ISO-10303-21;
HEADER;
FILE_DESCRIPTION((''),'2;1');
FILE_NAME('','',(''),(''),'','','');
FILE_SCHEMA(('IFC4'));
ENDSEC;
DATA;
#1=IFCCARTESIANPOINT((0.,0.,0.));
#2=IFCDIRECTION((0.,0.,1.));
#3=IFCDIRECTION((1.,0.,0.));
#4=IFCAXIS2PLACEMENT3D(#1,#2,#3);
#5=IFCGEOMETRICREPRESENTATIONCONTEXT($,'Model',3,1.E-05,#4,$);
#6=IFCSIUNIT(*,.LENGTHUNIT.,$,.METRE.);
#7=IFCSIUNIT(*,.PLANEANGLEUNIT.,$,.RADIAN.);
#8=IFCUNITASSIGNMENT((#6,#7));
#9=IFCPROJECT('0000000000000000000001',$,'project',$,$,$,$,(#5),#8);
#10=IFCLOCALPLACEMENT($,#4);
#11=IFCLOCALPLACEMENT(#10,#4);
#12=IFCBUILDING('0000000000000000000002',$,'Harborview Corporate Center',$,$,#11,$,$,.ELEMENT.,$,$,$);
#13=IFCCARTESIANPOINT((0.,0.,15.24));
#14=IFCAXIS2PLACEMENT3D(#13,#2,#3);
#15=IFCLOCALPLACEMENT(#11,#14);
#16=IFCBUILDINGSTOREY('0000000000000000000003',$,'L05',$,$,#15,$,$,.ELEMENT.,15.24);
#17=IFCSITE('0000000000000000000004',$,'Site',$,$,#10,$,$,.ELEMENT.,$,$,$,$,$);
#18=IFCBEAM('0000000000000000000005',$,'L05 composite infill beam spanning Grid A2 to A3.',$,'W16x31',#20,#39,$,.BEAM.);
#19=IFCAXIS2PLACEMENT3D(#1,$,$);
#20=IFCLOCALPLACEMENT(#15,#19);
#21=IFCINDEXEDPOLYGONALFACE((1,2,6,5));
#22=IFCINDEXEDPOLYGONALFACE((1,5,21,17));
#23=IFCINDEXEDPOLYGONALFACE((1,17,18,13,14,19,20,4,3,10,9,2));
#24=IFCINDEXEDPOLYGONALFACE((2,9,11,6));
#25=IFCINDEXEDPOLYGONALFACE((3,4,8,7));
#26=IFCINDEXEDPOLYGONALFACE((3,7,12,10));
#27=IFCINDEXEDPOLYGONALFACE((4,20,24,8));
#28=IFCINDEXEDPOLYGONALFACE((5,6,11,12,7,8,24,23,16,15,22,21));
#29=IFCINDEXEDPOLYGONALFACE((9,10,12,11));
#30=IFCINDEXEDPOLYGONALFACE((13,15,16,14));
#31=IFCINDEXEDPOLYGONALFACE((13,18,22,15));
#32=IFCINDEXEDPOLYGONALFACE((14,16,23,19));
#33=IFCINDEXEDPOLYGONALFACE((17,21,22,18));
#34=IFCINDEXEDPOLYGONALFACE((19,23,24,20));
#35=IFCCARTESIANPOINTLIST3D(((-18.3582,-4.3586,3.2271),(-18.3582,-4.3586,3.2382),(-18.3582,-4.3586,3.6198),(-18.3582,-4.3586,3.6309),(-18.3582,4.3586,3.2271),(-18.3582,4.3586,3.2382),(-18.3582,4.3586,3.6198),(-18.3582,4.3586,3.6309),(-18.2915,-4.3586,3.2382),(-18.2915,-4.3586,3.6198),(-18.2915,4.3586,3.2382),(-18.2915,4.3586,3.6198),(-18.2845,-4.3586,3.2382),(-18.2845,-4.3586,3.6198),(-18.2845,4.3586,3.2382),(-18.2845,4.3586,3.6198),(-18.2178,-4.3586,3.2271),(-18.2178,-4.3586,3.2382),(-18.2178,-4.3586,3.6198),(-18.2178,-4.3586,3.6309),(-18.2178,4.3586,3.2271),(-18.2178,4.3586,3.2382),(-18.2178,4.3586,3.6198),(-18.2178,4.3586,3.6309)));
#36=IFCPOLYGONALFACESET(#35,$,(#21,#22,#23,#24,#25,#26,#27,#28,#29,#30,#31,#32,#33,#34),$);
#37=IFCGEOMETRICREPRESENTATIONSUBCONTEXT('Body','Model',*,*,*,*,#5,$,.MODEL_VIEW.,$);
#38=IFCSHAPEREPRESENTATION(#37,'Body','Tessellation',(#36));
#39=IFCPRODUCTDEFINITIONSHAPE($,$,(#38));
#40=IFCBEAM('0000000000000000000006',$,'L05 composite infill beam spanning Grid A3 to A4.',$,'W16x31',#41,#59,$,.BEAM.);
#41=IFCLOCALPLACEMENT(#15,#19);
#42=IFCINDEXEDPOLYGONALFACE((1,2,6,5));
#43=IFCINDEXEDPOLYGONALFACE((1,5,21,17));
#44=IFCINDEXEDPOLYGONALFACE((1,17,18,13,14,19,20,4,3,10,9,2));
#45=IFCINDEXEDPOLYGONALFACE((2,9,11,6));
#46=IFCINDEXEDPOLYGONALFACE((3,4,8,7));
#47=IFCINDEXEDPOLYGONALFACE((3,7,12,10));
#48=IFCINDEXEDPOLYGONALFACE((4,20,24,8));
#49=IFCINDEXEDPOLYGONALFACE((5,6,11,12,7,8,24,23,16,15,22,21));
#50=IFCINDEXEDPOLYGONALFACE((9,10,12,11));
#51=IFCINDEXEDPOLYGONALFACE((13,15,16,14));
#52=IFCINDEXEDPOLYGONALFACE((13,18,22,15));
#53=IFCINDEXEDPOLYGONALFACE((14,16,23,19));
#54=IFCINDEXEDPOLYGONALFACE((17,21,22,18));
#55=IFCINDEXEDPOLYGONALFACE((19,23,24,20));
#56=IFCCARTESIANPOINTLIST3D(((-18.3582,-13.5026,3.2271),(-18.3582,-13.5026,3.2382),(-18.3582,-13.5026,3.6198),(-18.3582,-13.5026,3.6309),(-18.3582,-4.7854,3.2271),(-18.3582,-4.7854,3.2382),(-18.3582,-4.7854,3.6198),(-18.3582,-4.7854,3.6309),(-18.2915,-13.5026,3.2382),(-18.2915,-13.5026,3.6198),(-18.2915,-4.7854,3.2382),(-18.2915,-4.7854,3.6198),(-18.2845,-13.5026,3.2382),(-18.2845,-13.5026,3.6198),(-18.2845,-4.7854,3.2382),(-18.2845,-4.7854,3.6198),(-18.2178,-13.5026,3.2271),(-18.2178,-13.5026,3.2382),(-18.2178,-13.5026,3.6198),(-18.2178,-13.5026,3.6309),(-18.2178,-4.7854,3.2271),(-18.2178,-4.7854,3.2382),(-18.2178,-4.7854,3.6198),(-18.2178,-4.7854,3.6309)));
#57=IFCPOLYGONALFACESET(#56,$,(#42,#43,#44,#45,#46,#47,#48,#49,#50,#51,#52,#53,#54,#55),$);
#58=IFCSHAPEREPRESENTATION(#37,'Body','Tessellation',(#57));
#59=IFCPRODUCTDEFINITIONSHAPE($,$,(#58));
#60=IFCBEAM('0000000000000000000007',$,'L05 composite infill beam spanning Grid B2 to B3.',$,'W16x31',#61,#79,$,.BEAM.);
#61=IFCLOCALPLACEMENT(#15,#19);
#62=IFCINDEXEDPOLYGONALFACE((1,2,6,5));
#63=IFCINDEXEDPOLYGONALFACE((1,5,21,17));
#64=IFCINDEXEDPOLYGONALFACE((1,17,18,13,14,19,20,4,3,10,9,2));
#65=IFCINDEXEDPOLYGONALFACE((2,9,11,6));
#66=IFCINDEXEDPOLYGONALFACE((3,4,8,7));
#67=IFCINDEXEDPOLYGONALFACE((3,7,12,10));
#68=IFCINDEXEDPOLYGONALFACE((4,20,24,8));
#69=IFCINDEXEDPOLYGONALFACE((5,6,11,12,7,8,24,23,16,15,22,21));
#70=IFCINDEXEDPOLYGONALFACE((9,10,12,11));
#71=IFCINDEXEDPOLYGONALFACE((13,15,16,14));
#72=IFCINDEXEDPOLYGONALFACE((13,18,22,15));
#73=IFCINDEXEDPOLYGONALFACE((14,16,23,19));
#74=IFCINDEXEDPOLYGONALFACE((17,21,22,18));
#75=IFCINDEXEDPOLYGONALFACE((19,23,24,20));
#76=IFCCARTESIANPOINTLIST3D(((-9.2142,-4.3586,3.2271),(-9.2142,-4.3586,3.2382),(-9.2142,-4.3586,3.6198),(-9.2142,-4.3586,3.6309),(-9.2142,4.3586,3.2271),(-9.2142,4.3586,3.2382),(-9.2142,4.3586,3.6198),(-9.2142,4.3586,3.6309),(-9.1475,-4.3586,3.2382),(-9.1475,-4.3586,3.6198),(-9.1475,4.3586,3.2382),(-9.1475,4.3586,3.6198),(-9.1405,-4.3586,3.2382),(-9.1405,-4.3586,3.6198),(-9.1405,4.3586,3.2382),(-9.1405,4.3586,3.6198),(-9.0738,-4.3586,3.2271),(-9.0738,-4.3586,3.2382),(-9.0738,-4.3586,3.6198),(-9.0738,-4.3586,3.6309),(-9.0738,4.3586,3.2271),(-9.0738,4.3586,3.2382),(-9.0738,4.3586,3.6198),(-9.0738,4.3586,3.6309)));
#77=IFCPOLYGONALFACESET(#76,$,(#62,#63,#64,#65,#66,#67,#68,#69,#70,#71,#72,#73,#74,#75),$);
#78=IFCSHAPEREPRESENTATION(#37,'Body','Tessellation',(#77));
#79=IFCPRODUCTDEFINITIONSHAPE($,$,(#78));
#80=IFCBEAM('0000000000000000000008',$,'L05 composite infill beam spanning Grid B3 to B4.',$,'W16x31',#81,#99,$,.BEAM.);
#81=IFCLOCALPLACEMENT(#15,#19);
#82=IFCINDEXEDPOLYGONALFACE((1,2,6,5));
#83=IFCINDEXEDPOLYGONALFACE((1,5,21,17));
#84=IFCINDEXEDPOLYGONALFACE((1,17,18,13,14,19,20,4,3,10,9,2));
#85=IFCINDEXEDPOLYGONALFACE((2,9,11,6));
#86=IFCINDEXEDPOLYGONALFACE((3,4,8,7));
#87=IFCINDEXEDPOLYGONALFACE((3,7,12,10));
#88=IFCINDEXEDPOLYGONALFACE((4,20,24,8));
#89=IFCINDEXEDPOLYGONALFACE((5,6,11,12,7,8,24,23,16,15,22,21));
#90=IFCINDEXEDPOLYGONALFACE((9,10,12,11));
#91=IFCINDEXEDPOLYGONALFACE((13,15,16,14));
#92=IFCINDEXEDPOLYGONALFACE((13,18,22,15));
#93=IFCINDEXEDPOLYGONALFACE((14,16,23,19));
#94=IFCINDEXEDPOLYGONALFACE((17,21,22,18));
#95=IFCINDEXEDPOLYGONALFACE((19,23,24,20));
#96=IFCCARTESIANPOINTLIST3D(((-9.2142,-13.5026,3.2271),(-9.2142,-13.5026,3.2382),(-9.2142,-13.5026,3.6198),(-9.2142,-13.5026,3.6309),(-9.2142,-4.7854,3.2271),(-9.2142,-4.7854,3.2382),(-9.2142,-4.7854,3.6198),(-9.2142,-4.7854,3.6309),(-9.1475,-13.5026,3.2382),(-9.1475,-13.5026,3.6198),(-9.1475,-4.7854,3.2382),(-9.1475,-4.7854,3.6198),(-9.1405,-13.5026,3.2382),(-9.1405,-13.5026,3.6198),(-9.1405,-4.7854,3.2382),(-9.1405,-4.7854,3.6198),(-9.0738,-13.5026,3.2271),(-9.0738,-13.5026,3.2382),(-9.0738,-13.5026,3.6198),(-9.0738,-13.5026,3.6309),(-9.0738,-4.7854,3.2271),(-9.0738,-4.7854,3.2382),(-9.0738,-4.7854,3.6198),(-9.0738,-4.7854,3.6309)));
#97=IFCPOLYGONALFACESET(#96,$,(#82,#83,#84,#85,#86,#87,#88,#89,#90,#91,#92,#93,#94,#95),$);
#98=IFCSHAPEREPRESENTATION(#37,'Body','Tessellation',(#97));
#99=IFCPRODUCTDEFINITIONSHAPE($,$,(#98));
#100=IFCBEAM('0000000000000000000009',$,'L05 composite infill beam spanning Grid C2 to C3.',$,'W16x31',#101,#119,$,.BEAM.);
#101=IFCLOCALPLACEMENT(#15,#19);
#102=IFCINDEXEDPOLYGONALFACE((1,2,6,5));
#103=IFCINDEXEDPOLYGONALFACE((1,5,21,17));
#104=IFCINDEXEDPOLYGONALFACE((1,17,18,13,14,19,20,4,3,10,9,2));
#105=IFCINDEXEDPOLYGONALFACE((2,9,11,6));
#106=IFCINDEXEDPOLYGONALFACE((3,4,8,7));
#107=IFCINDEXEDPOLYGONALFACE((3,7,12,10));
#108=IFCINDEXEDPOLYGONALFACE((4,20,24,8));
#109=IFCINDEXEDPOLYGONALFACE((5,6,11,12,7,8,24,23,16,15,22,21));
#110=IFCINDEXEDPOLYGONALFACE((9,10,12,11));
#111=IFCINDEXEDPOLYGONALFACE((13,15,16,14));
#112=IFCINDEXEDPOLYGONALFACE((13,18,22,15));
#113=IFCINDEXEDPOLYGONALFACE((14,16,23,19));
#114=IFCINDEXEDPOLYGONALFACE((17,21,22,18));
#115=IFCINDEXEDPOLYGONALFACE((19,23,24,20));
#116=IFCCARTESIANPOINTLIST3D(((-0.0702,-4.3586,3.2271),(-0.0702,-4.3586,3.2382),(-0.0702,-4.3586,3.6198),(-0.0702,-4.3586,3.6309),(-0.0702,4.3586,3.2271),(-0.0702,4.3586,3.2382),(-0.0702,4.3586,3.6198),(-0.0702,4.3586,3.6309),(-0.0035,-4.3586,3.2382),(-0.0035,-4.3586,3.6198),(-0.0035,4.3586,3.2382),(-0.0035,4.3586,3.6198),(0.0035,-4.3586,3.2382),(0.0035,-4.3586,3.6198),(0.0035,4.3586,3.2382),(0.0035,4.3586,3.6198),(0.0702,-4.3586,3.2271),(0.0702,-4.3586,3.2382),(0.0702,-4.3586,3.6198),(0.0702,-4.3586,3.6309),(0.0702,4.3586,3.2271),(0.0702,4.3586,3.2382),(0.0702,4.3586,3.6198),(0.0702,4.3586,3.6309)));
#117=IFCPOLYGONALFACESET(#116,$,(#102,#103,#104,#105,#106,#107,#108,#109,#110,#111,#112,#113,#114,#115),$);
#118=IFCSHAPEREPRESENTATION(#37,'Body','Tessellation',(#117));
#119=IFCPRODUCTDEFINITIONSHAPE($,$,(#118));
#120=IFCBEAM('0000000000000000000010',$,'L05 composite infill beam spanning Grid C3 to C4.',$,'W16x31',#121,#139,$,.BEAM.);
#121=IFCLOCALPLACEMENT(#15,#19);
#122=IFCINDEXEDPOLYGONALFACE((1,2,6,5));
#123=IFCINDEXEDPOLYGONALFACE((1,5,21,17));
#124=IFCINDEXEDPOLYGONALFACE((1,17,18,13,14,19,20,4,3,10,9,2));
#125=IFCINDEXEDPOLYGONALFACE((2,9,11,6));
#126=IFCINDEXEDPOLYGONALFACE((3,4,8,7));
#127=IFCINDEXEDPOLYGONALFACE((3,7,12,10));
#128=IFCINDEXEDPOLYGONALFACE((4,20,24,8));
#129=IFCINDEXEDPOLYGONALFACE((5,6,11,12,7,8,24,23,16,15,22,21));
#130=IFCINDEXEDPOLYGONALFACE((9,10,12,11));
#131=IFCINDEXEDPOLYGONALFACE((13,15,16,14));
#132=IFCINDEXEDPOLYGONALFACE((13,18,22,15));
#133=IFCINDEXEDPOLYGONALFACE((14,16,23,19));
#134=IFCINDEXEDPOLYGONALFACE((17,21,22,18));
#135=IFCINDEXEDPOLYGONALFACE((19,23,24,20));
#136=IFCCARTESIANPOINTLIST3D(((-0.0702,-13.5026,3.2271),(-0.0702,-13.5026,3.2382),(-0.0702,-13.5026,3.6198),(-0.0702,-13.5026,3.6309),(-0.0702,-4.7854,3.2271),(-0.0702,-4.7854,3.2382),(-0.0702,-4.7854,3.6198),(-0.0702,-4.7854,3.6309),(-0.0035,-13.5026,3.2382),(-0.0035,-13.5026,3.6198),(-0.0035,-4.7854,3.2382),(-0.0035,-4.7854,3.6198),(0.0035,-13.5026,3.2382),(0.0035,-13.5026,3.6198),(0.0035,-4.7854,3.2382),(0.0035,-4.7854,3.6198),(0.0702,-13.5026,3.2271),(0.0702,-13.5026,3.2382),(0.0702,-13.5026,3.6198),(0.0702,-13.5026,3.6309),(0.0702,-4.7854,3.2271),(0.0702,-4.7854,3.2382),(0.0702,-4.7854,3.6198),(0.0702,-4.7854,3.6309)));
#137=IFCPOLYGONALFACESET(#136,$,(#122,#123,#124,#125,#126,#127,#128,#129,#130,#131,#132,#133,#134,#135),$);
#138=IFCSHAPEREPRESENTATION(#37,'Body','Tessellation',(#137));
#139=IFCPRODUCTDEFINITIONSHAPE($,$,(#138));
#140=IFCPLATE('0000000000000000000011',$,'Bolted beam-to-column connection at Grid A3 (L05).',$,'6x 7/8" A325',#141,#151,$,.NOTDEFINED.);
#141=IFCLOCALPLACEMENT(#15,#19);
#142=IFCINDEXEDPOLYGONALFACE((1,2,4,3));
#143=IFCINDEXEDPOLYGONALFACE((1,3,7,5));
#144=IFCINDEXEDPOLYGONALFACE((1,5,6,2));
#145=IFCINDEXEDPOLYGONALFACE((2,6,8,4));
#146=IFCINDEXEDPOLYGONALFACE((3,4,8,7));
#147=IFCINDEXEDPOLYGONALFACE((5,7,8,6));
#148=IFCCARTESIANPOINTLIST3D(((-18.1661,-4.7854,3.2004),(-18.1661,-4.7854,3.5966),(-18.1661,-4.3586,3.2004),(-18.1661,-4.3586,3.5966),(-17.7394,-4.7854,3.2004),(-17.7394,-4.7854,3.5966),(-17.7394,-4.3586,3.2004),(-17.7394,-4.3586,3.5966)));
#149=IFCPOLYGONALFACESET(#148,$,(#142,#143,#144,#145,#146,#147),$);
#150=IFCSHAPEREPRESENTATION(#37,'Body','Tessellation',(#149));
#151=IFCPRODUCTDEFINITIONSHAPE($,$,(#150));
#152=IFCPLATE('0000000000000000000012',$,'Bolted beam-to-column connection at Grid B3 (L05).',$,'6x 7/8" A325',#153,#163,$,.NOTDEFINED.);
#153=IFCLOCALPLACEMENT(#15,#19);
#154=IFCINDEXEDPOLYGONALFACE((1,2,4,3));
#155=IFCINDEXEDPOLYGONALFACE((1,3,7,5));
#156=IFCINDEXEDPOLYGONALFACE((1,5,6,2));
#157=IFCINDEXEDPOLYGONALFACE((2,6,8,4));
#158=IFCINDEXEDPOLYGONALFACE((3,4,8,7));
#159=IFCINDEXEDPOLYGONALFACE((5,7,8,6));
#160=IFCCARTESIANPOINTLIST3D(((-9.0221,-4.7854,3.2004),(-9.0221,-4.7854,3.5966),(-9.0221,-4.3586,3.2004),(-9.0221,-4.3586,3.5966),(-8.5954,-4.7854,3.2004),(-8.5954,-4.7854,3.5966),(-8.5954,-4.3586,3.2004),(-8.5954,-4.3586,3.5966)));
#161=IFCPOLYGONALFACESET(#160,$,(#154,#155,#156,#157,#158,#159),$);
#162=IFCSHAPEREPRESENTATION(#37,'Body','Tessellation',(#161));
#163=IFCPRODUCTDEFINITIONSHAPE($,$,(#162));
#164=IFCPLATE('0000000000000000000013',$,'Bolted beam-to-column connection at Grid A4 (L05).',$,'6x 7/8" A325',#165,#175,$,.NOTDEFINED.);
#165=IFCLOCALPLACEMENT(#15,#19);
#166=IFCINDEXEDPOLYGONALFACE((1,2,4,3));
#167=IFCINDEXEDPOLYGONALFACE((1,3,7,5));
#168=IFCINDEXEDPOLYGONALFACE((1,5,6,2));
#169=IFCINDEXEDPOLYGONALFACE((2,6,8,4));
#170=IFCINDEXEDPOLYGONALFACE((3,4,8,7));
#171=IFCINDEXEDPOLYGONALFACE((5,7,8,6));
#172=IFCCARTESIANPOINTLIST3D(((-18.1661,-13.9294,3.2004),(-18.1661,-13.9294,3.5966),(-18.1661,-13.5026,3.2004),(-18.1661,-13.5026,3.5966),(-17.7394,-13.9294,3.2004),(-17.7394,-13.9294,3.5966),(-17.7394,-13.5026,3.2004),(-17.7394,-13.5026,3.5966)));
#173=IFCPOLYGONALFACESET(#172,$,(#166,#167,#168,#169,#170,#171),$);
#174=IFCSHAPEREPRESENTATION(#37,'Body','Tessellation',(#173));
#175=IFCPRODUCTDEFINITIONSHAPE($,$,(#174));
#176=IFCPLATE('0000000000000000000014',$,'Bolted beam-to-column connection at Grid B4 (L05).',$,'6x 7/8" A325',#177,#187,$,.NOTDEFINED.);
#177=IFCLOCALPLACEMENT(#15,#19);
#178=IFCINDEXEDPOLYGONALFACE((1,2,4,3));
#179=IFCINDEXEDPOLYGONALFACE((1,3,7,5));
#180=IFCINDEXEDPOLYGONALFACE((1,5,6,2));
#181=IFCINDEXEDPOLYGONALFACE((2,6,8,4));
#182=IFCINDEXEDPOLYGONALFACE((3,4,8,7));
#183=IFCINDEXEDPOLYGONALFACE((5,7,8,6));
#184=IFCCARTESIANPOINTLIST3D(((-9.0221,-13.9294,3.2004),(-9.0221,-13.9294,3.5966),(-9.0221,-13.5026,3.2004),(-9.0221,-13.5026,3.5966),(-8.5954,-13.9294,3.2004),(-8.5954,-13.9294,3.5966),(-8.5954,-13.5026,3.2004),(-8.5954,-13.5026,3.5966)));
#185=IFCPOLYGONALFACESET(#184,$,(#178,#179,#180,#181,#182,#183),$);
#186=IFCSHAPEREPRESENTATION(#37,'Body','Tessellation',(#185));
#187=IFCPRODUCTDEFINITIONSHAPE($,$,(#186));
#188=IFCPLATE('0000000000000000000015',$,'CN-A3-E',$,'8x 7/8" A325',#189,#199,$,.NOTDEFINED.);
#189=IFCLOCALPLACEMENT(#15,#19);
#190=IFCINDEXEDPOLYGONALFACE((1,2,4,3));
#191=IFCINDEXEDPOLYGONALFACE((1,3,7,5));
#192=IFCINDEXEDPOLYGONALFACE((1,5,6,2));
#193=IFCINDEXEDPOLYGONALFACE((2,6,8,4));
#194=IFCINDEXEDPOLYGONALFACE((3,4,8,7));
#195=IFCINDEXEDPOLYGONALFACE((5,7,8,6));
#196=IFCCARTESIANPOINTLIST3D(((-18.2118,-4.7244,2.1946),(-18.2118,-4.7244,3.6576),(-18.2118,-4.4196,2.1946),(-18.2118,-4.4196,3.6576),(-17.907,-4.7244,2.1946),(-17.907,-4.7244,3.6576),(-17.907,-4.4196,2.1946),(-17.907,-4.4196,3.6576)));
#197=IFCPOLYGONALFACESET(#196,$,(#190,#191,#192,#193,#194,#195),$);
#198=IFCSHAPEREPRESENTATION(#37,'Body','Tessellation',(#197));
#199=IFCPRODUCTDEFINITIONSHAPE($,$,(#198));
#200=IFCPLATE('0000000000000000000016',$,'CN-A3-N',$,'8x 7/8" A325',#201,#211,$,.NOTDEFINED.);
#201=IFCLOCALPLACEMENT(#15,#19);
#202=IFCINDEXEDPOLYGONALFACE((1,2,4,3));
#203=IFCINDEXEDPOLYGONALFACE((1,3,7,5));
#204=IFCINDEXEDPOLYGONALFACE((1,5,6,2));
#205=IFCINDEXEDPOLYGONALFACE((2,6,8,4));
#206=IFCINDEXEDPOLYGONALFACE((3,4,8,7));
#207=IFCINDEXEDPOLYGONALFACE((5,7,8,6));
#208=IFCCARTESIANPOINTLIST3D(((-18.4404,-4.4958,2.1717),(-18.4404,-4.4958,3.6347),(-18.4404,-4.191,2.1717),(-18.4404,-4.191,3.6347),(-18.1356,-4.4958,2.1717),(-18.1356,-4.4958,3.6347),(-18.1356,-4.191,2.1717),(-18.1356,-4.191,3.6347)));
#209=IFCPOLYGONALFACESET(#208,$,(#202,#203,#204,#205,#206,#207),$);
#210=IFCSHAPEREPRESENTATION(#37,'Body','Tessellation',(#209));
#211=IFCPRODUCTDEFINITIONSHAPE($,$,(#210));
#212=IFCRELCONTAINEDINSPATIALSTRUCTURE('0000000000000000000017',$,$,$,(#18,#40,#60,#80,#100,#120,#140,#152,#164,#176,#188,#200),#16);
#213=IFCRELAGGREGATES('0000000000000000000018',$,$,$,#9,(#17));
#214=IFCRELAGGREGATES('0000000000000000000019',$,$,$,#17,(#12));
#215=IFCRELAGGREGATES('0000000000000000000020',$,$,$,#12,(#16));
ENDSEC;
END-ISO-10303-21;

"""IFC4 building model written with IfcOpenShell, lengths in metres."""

from ifc_helpers import new_model, si_unit, frame, origin_with_axes, place, context, subcontext, project, spatial, rectangle, i_section, extrude, element, save


model = new_model("IFC4")

# Units and contexts
model_context = context("Model", 3, precision=1e-05, world=origin_with_axes())
body_context = subcontext(model_context, "Body", "Model", "MODEL_VIEW")
ifc_project = project(units=[si_unit("LENGTHUNIT", "METRE"), si_unit("PLANEANGLEUNIT", "RADIAN")], contexts=[model_context])

# Site, building, storey
site_placement = place(None, origin_with_axes())
site = spatial("IfcSite", under=ifc_project, at=site_placement, Name="Site", CompositionType="ELEMENT")
building_placement = place(site_placement, origin_with_axes())
building = spatial("IfcBuilding", under=site, at=building_placement, Name="Harborview Corporate Center", CompositionType="ELEMENT")
storey_placement = place(building_placement, frame((0.0, 0.0, 15.24), z_axis=(0.0, 0.0, 1.0), x_axis=(1.0, 0.0, 0.0)))
storey = spatial("IfcBuildingStorey", under=building, at=storey_placement, Name="L05", CompositionType="ELEMENT", Elevation=15.24)

# Beams
beam_1_placement = place(storey_placement, frame((-18.288, -4.3586, 3.429), z_axis=(0.0, 1.0, 0.0), x_axis=(-1.0, 0.0, 0.0)))
element("IfcBeam", 1, at=beam_1_placement, inside=storey, Name="L05 composite infill beam spanning Grid A2 to A3.", ObjectType="W16x31", PredefinedType="BEAM", context=body_context, shape_type="SweptSolid", body=[
    extrude(i_section(OverallWidth=0.1405, OverallDepth=0.4039, WebThickness=0.007, FlangeThickness=0.0112), origin_with_axes(), (0.0, 0.0, 1.0), 8.7173),
])
beam_2_placement = place(storey_placement, frame((-18.288, -13.5026, 3.429), z_axis=(0.0, 1.0, 0.0), x_axis=(-1.0, 0.0, 0.0)))
element("IfcBeam", 2, at=beam_2_placement, inside=storey, Name="L05 composite infill beam spanning Grid A3 to A4.", ObjectType="W16x31", PredefinedType="BEAM", context=body_context, shape_type="SweptSolid", body=[
    extrude(i_section(OverallWidth=0.1405, OverallDepth=0.4039, WebThickness=0.007, FlangeThickness=0.0112), origin_with_axes(), (0.0, 0.0, 1.0), 8.7173),
])
beam_3_placement = place(storey_placement, frame((-9.144, -4.3586, 3.429), z_axis=(0.0, 1.0, 0.0), x_axis=(-1.0, 0.0, 0.0)))
element("IfcBeam", 3, at=beam_3_placement, inside=storey, Name="L05 composite infill beam spanning Grid B2 to B3.", ObjectType="W16x31", PredefinedType="BEAM", context=body_context, shape_type="SweptSolid", body=[
    extrude(i_section(OverallWidth=0.1405, OverallDepth=0.4039, WebThickness=0.007, FlangeThickness=0.0112), origin_with_axes(), (0.0, 0.0, 1.0), 8.7173),
])
beam_4_placement = place(storey_placement, frame((-9.144, -13.5026, 3.429), z_axis=(0.0, 1.0, 0.0), x_axis=(-1.0, 0.0, 0.0)))
element("IfcBeam", 4, at=beam_4_placement, inside=storey, Name="L05 composite infill beam spanning Grid B3 to B4.", ObjectType="W16x31", PredefinedType="BEAM", context=body_context, shape_type="SweptSolid", body=[
    extrude(i_section(OverallWidth=0.1405, OverallDepth=0.4039, WebThickness=0.007, FlangeThickness=0.0112), origin_with_axes(), (0.0, 0.0, 1.0), 8.7173),
])
beam_5_placement = place(storey_placement, frame((0.0, -4.3586, 3.429), z_axis=(0.0, 1.0, 0.0), x_axis=(-1.0, 0.0, 0.0)))
element("IfcBeam", 5, at=beam_5_placement, inside=storey, Name="L05 composite infill beam spanning Grid C2 to C3.", ObjectType="W16x31", PredefinedType="BEAM", context=body_context, shape_type="SweptSolid", body=[
    extrude(i_section(OverallWidth=0.1405, OverallDepth=0.4039, WebThickness=0.007, FlangeThickness=0.0112), origin_with_axes(), (0.0, 0.0, 1.0), 8.7173),
])
beam_6_placement = place(storey_placement, frame((0.0, -13.5026, 3.429), z_axis=(0.0, 1.0, 0.0), x_axis=(-1.0, 0.0, 0.0)))
element("IfcBeam", 6, at=beam_6_placement, inside=storey, Name="L05 composite infill beam spanning Grid C3 to C4.", ObjectType="W16x31", PredefinedType="BEAM", context=body_context, shape_type="SweptSolid", body=[
    extrude(i_section(OverallWidth=0.1405, OverallDepth=0.4039, WebThickness=0.007, FlangeThickness=0.0112), origin_with_axes(), (0.0, 0.0, 1.0), 8.7173),
])

# Plates
plate_1_placement = place(storey_placement, frame((-17.9527, -4.572, 3.2004), z_axis=(0.0, 0.0, 1.0), x_axis=(1.0, 0.0, 0.0)))
element("IfcPlate", 7, at=plate_1_placement, inside=storey, Name="Bolted beam-to-column connection at Grid A3 (L05).", ObjectType="6x 7/8\" A325", PredefinedType="NOTDEFINED", context=body_context, shape_type="SweptSolid", body=[
    extrude(rectangle(XDim=0.4267, YDim=0.4267), origin_with_axes(), (0.0, 0.0, 1.0), 0.3962),
])
plate_2_placement = place(storey_placement, frame((-8.8087, -4.572, 3.2004), z_axis=(0.0, 0.0, 1.0), x_axis=(1.0, 0.0, 0.0)))
element("IfcPlate", 8, at=plate_2_placement, inside=storey, Name="Bolted beam-to-column connection at Grid B3 (L05).", ObjectType="6x 7/8\" A325", PredefinedType="NOTDEFINED", context=body_context, shape_type="SweptSolid", body=[
    extrude(rectangle(XDim=0.4267, YDim=0.4267), origin_with_axes(), (0.0, 0.0, 1.0), 0.3962),
])
plate_3_placement = place(storey_placement, frame((-17.9527, -13.716, 3.2004), z_axis=(0.0, 0.0, 1.0), x_axis=(1.0, 0.0, 0.0)))
element("IfcPlate", 9, at=plate_3_placement, inside=storey, Name="Bolted beam-to-column connection at Grid A4 (L05).", ObjectType="6x 7/8\" A325", PredefinedType="NOTDEFINED", context=body_context, shape_type="SweptSolid", body=[
    extrude(rectangle(XDim=0.4267, YDim=0.4267), origin_with_axes(), (0.0, 0.0, 1.0), 0.3962),
])
plate_4_placement = place(storey_placement, frame((-8.8087, -13.716, 3.2004), z_axis=(0.0, 0.0, 1.0), x_axis=(1.0, 0.0, 0.0)))
element("IfcPlate", 10, at=plate_4_placement, inside=storey, Name="Bolted beam-to-column connection at Grid B4 (L05).", ObjectType="6x 7/8\" A325", PredefinedType="NOTDEFINED", context=body_context, shape_type="SweptSolid", body=[
    extrude(rectangle(XDim=0.4267, YDim=0.4267), origin_with_axes(), (0.0, 0.0, 1.0), 0.3962),
])
for number, where, z_axis, x_axis, name in (
    (11, (-18.0594, -4.572, 2.1946), (0.0, 0.0, 1.0), (1.0, 0.0, 0.0), "CN-A3-E"),
    (12, (-18.288, -4.3434, 2.1717), (0.0, 0.0, 1.0), (1.0, 0.0, 0.0), "CN-A3-N"),
):
    element("IfcPlate", number, at=place(storey_placement, frame(where, z_axis=z_axis, x_axis=x_axis)), inside=storey, Name=name, ObjectType="8x 7/8\" A325", PredefinedType="NOTDEFINED", context=body_context, shape_type="SweptSolid", body=[
        extrude(rectangle(XDim=0.3048, YDim=0.3048), origin_with_axes(), (0.0, 0.0, 1.0), 1.463),
    ])

save(model, "model.ifc")
